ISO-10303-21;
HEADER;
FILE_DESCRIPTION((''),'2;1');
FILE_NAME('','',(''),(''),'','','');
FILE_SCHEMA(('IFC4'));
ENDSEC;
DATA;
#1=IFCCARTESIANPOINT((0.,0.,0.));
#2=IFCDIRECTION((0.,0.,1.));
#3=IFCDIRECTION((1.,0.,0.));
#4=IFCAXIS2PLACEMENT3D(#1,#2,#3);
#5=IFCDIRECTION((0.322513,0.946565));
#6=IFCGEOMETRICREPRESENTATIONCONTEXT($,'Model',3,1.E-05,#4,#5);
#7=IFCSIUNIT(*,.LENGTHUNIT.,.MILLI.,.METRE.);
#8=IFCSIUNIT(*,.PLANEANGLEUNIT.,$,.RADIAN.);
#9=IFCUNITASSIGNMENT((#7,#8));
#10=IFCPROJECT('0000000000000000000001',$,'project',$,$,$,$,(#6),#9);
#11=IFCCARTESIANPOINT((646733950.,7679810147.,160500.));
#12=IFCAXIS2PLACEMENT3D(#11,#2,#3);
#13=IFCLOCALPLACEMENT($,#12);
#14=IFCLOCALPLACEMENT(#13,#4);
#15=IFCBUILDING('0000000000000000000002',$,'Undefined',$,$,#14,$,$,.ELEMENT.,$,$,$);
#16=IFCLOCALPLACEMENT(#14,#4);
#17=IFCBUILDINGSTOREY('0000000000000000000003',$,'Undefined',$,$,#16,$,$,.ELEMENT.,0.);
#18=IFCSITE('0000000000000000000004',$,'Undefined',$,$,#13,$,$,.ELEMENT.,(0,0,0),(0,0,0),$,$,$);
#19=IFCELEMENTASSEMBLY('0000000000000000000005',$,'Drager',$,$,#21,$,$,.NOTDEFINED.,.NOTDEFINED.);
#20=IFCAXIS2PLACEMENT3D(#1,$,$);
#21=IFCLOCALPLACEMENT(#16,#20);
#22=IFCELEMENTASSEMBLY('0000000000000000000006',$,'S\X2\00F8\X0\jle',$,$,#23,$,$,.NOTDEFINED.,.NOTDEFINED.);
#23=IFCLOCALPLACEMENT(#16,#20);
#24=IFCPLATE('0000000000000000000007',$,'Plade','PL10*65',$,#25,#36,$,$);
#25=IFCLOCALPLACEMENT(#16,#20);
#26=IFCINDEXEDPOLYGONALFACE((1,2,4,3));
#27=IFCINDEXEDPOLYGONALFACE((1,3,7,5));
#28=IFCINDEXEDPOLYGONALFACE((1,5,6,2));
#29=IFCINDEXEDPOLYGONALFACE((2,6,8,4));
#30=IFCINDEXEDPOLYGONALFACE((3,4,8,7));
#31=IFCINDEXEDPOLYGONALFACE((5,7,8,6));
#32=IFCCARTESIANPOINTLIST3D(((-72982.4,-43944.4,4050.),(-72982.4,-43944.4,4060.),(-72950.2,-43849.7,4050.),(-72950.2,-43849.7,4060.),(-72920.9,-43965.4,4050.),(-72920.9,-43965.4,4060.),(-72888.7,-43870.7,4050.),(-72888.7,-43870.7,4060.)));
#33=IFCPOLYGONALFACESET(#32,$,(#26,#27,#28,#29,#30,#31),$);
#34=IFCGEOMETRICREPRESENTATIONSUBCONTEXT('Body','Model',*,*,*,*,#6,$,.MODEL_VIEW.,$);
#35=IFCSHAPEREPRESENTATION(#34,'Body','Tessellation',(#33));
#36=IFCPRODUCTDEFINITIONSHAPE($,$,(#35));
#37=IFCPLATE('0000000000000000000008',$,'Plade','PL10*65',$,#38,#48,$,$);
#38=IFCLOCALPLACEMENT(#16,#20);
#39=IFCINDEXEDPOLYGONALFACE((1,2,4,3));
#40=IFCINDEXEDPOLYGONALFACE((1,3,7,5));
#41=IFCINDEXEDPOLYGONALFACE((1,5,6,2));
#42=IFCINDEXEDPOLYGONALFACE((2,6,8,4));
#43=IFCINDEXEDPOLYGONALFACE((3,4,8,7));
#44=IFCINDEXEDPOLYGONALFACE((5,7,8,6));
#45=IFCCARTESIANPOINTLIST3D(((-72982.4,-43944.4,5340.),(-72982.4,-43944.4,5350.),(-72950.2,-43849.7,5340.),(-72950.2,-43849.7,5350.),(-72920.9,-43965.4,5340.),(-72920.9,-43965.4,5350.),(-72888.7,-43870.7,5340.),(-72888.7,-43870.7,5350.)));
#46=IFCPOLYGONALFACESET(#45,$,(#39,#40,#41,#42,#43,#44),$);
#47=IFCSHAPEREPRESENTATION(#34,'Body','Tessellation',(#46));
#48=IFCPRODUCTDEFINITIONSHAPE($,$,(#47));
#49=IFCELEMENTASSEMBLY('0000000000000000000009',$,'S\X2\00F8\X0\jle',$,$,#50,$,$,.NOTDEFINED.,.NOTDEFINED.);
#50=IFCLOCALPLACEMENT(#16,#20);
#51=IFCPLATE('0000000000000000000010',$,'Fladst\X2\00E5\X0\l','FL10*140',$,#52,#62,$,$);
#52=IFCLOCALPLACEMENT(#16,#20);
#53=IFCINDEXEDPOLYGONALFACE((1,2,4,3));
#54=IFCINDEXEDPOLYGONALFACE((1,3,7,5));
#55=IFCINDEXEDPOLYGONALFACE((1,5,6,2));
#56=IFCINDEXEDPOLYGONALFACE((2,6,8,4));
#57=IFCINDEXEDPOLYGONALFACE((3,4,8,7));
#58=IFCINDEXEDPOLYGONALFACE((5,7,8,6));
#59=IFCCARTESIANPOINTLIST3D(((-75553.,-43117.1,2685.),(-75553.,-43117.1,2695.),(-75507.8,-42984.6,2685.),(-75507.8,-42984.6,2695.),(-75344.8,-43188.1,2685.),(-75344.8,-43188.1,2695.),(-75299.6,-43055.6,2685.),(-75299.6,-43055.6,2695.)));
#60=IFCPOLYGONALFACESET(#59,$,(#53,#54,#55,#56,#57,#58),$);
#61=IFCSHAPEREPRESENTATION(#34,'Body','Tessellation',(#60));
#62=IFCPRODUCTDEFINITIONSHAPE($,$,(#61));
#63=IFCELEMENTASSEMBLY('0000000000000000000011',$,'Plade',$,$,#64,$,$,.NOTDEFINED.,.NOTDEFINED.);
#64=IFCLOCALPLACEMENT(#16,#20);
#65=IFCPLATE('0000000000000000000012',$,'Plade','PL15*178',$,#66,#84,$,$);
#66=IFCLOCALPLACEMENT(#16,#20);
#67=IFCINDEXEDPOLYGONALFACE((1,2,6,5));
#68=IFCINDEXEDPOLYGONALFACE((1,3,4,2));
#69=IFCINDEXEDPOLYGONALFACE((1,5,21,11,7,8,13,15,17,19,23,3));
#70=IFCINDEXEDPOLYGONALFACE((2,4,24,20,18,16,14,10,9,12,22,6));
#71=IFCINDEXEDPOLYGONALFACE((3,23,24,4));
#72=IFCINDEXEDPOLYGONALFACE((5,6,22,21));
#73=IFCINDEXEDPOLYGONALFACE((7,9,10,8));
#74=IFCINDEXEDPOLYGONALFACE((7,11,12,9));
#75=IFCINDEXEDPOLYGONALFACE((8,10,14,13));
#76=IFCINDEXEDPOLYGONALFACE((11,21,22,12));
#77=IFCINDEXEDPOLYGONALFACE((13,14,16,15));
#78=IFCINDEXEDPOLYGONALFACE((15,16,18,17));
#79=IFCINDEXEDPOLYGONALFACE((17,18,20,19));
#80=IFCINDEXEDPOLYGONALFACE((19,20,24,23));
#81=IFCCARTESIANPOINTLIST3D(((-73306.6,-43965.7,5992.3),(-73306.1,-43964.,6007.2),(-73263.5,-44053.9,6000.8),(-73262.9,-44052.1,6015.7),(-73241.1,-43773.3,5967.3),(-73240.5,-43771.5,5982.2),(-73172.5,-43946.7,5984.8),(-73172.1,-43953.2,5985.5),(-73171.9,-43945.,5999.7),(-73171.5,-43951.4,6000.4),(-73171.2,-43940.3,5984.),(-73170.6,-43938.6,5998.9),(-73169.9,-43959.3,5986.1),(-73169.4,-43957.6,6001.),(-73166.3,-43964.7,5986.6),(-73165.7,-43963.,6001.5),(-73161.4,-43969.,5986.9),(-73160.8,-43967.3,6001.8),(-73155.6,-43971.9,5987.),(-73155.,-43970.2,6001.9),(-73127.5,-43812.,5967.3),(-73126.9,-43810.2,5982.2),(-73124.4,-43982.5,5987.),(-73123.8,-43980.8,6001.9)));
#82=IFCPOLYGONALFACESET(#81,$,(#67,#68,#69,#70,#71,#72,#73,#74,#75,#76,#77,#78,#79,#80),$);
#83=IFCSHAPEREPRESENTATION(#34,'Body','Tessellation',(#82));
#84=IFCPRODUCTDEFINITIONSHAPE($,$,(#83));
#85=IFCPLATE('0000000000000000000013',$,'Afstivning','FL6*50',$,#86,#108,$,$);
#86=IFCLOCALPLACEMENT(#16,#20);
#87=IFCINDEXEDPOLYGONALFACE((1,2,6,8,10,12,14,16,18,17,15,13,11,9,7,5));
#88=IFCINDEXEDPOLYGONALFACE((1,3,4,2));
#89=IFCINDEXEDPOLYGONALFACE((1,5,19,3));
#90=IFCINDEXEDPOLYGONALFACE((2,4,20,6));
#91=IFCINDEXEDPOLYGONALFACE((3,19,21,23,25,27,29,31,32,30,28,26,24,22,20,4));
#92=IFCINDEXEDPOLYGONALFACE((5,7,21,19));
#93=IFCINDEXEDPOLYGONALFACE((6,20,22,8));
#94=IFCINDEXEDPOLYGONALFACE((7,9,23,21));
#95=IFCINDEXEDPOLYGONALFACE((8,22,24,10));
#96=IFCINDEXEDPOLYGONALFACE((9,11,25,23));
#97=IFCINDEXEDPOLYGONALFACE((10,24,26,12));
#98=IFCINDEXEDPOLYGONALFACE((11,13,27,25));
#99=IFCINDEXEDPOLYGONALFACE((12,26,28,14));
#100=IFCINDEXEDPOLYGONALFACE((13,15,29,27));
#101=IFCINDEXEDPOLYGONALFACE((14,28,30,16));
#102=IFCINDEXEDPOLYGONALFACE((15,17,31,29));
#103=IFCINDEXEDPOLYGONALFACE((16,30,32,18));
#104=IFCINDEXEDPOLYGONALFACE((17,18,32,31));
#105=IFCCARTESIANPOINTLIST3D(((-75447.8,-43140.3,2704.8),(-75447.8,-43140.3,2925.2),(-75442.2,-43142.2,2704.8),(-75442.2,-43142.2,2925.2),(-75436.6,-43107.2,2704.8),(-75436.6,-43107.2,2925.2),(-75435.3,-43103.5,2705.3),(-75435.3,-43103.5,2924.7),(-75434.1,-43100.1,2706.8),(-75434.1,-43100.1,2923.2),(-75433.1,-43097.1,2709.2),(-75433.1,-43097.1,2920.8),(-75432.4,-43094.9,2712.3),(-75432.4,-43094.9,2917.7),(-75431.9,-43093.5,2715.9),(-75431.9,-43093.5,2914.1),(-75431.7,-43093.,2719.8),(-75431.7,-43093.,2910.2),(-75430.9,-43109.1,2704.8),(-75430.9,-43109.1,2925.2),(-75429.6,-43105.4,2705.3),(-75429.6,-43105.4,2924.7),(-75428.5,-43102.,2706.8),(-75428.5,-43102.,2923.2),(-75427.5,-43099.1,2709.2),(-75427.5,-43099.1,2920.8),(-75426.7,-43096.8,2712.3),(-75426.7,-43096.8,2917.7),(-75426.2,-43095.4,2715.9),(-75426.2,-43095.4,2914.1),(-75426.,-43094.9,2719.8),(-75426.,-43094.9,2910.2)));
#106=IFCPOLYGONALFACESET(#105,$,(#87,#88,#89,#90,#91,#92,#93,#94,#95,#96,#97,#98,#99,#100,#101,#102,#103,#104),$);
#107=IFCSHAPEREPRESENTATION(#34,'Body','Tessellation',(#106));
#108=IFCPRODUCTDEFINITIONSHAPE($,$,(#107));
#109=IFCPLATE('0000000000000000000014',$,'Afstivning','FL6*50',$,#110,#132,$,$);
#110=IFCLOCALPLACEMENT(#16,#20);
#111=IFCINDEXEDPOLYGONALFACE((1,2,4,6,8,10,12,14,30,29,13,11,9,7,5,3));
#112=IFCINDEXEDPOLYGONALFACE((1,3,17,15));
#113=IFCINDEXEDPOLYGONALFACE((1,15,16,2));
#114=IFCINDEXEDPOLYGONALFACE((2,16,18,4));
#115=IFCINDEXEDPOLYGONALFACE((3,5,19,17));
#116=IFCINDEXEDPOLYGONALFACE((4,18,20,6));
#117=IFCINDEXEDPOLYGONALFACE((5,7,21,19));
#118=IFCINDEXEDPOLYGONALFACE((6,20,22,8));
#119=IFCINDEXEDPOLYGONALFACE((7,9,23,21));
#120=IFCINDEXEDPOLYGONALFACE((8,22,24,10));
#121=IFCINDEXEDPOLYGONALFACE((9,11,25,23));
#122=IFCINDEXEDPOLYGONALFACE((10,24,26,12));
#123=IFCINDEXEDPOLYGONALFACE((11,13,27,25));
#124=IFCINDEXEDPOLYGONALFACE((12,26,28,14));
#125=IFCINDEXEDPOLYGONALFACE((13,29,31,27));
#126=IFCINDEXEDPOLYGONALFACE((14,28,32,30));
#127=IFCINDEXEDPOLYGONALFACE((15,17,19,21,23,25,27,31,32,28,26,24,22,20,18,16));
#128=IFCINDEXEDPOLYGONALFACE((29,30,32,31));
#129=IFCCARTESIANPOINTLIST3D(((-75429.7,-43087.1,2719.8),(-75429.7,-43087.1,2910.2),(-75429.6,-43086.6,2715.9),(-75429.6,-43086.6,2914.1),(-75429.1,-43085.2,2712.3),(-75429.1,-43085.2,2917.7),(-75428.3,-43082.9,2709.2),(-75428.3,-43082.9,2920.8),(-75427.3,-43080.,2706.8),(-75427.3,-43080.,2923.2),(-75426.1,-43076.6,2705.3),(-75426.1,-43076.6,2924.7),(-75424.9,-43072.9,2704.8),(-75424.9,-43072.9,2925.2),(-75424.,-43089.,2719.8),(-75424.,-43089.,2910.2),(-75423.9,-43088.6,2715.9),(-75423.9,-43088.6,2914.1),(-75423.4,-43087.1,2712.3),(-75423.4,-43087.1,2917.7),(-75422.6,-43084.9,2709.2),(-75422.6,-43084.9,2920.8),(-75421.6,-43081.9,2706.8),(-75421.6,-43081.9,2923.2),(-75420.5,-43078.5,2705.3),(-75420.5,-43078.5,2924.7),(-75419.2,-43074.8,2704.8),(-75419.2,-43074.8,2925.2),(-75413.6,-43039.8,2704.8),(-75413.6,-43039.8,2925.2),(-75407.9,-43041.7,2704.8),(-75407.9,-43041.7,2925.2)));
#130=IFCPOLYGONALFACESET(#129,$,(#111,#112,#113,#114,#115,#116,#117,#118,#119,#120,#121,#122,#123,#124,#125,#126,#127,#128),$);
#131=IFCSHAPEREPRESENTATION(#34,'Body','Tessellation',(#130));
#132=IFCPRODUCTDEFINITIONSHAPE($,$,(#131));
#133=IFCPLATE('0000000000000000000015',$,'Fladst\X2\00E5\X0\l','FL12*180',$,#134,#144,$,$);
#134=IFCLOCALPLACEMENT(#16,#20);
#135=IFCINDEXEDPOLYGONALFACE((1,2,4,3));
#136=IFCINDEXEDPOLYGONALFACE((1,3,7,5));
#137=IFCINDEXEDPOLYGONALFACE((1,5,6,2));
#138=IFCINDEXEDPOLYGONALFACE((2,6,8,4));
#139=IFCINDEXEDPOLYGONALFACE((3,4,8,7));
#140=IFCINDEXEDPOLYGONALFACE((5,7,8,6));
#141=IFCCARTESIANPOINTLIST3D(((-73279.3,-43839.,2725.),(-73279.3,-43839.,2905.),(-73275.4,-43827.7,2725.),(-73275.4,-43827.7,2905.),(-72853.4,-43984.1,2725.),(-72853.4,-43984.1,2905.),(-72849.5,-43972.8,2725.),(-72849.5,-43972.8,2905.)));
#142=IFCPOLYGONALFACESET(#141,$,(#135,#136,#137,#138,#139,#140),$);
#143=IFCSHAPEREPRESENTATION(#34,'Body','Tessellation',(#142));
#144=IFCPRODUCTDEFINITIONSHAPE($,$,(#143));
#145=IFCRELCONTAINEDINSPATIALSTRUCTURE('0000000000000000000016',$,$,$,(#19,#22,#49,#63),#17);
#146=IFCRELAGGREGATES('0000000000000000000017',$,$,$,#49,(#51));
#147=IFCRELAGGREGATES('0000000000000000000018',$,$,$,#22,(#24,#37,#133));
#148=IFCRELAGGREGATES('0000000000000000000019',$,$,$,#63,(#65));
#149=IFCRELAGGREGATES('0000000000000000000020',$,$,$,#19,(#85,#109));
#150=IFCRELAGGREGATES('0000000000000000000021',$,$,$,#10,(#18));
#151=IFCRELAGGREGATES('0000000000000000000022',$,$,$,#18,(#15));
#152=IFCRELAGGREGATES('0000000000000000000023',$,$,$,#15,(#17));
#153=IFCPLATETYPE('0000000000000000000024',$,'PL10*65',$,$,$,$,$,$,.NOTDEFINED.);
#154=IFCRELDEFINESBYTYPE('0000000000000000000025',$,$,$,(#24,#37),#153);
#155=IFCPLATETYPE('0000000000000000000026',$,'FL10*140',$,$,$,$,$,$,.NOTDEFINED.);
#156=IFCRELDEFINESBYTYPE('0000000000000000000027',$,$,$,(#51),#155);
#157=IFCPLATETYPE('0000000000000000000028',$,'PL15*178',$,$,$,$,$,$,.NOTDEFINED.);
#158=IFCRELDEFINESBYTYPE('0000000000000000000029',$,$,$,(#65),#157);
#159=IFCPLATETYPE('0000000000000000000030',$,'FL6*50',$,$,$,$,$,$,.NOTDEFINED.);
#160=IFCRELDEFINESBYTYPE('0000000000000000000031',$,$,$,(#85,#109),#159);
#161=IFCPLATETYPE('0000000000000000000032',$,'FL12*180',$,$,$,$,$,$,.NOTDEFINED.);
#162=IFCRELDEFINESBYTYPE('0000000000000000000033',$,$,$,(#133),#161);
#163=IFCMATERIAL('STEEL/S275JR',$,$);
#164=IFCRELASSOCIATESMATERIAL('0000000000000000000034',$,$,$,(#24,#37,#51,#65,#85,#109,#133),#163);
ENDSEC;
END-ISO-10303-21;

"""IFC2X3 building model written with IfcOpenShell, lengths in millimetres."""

from ifc_helpers import new_model, si_unit, direction, frame, frame_2d, origin_with_axes, place, context, subcontext, project, spatial, polyline, circle_curve, parameter, trimmed, segment, composite_curve, outline, extrude, material, type_object, element, aggregate, save


model = new_model("IFC2X3")

# Units and contexts
model_context = context("Model", 3, precision=1e-05, world=origin_with_axes(), true_north=direction((0.322513, 0.946565)))
body_context = subcontext(model_context, "Body", "Model", "MODEL_VIEW")
ifc_project = project(units=[si_unit("LENGTHUNIT", "METRE", prefix="MILLI"), si_unit("PLANEANGLEUNIT", "RADIAN")], contexts=[model_context])

# Site, building, storey
site_placement = place(None, frame((646733950.0, 7679810147.0, 160500.0), z_axis=(0.0, 0.0, 1.0), x_axis=(1.0, 0.0, 0.0)))
site = spatial("IfcSite", under=ifc_project, at=site_placement, Name="Undefined", CompositionType="ELEMENT", RefLatitude=(0, 0, 0), RefLongitude=(0, 0, 0))
building_placement = place(site_placement, origin_with_axes())
building = spatial("IfcBuilding", under=site, at=building_placement, Name="Undefined", CompositionType="ELEMENT")
storey_placement = place(building_placement, origin_with_axes())
storey = spatial("IfcBuildingStorey", under=building, at=storey_placement, Name="Undefined", CompositionType="ELEMENT", Elevation=0.0)

# Element assembly
assembly_1_placement = place(storey_placement, origin_with_axes())
assembly_1 = element("IfcElementAssembly", 1, at=assembly_1_placement, inside=storey, Name="Drager", AssemblyPlace="NOTDEFINED", PredefinedType="NOTDEFINED")

# Shared definitions
ifc_material_1 = material(Name="STEEL/S275JR")

# Element assembly
assembly_2_placement = place(storey_placement, origin_with_axes())
assembly_2 = element("IfcElementAssembly", 2, at=assembly_2_placement, inside=storey, Name="Søjle", AssemblyPlace="NOTDEFINED", PredefinedType="NOTDEFINED")

# Plates
plate_type_1 = type_object("IfcPlateType", Name="PL10*65", PredefinedType="NOTDEFINED")
plate_1_placement = place(assembly_2_placement, frame((-72982.4, -43944.4, 4055.0), z_axis=(0.0, 0.0, 1.0), x_axis=(0.946565, -0.322513, 0.0)))
plate_1 = element("IfcPlate", 3, at=plate_1_placement, type_object=plate_type_1, material=ifc_material_1, Name="Plade", Description="PL10*65", context=body_context, shape_type="SweptSolid", body=[
    extrude(outline(polyline([(0.0, 0.0), (65.0, 0.0), (65.0, 100.0), (0.0, 100.0), (0.0, 0.0)])), frame((0.0, 0.0, -5.0), z_axis=(0.0, 0.0, 1.0), x_axis=(1.0, 0.0, 0.0)), (0.0, 0.0, 1.0), 10.0),
])
plate_2_placement = place(assembly_2_placement, frame((-72982.4, -43944.4, 5345.0), z_axis=(0.0, 0.0, 1.0), x_axis=(0.946565, -0.322513, 0.0)))
plate_2 = element("IfcPlate", 4, at=plate_2_placement, type_object=plate_type_1, material=ifc_material_1, Name="Plade", Description="PL10*65", context=body_context, shape_type="SweptSolid", body=[
    extrude(outline(polyline([(0.0, 0.0), (65.0, 0.0), (65.0, 100.0), (0.0, 100.0), (0.0, 0.0)])), frame((0.0, 0.0, -5.0), z_axis=(0.0, 0.0, 1.0), x_axis=(1.0, 0.0, 0.0)), (0.0, 0.0, 1.0), 10.0),
])

# Element assemblies, plates
assembly_3_placement = place(storey_placement, origin_with_axes())
assembly_3 = element("IfcElementAssembly", 5, at=assembly_3_placement, inside=storey, Name="Søjle", AssemblyPlace="NOTDEFINED", PredefinedType="NOTDEFINED")
plate_type_2 = type_object("IfcPlateType", Name="FL10*140", PredefinedType="NOTDEFINED")
plate_3_placement = place(assembly_3_placement, frame((-75403.7, -43020.1, 2690.0), z_axis=(0.0, 0.0, -1.0), x_axis=(-0.322513, -0.946565, 0.0)))
plate_3 = element("IfcPlate", 6, at=plate_3_placement, type_object=plate_type_2, material=ifc_material_1, Name="Fladstål", Description="FL10*140", context=body_context, shape_type="SweptSolid", body=[
    extrude(outline(polyline([(0.0, -110.0), (0.0, 110.0), (140.0, 110.0), (140.0, -110.0), (0.0, -110.0)])), frame((0.0, 0.0, -5.0), z_axis=(0.0, 0.0, 1.0), x_axis=(1.0, 0.0, 0.0)), (0.0, 0.0, 1.0), 10.0),
])
aggregate(assembly_3, [plate_3])
assembly_4_placement = place(storey_placement, origin_with_axes())
assembly_4 = element("IfcElementAssembly", 7, at=assembly_4_placement, inside=storey, Name="Plade", AssemblyPlace="NOTDEFINED", PredefinedType="NOTDEFINED")
plate_type_3 = type_object("IfcPlateType", Name="PL15*178", PredefinedType="NOTDEFINED")
plate_4_placement = place(assembly_4_placement, frame((-73127.2, -43811.1, 5974.8), z_axis=(-0.039304, -0.115357, -0.992546), x_axis=(-0.320109, -0.93951, 0.121869)))
plate_4 = element("IfcPlate", 8, at=plate_4_placement, type_object=plate_type_3, material=ifc_material_1, Name="Plade", Description="PL15*178", context=body_context, shape_type="SweptSolid", body=[
    extrude(outline(composite_curve([segment(polyline([(0.0, 0.0), (136.6, 0.0)]), True, "CONTINUOUS"), segment(trimmed(circle_curve(frame_2d((136.6, -25.0), x_axis=(0.0, 1.0)), 25.0), [parameter(0.0)], [parameter(4.712327)], False, "PARAMETER"), True, "CONTINUOUS"), segment(polyline([(161.6, -25.0), (161.6, -57.9), (274.9, 50.8), (204.9, 120.0), (0.0, 120.0), (0.0, 0.0)]), True, "CONTINUOUS")], self_intersect=True)), frame((0.0, 0.0, -7.5), z_axis=(0.0, 0.0, 1.0), x_axis=(1.0, 0.0, 0.0)), (0.0, 0.0, 1.0), 15.0),
])

# Plates
plate_type_4 = type_object("IfcPlateType", Name="FL6*50", PredefinedType="NOTDEFINED")
plate_5_placement = place(assembly_1_placement, frame((-75428.9, -43093.9, 2704.8), z_axis=(-0.946565, 0.322513, 0.0), x_axis=(-0.322513, -0.946565, 0.0)))
plate_5 = element("IfcPlate", 9, at=plate_5_placement, type_object=plate_type_4, material=ifc_material_1, Name="Afstivning", Description="FL6*50", context=body_context, shape_type="SweptSolid", body=[
    extrude(outline(composite_curve([segment(trimmed(circle_curve(frame_2d((15.0, 15.0), x_axis=(-1.0, 0.0)), 15.0), [parameter(0.0)], [parameter(1.570796)], True, "PARAMETER"), True, "CONTINUOUS"), segment(polyline([(15.0, 0.0), (50.0, 0.0), (50.0, 220.4), (15.0, 220.4)]), True, "CONTINUOUS"), segment(trimmed(circle_curve(frame_2d((15.0, 205.4), x_axis=(0.0, 1.0)), 15.0), [parameter(0.0)], [parameter(1.570796)], True, "PARAMETER"), True, "CONTINUOUS"), segment(polyline([(0.0, 205.4), (0.0, 15.0)]), True, "CONTINUOUS")], self_intersect=True)), frame((0.0, 0.0, -3.0), z_axis=(0.0, 0.0, 1.0), x_axis=(1.0, 0.0, 0.0)), (0.0, 0.0, 1.0), 6.0),
])
plate_6_placement = place(assembly_1_placement, frame((-75410.8, -43040.7, 2704.8), z_axis=(-0.946565, 0.322513, 0.0), x_axis=(-0.322513, -0.946565, 0.0)))
plate_6 = element("IfcPlate", 10, at=plate_6_placement, type_object=plate_type_4, material=ifc_material_1, Name="Afstivning", Description="FL6*50", context=body_context, shape_type="SweptSolid", body=[
    extrude(outline(composite_curve([segment(polyline([(0.0, 0.0), (35.0, 0.0)]), True, "CONTINUOUS"), segment(trimmed(circle_curve(frame_2d((35.0, 15.0), x_axis=(0.0, -1.0)), 15.0), [parameter(0.0)], [parameter(1.570796)], True, "PARAMETER"), True, "CONTINUOUS"), segment(polyline([(50.0, 15.0), (50.0, 205.4)]), True, "CONTINUOUS"), segment(trimmed(circle_curve(frame_2d((35.0, 205.4), x_axis=(1.0, 0.0)), 15.0), [parameter(0.0)], [parameter(1.570796)], True, "PARAMETER"), True, "CONTINUOUS"), segment(polyline([(35.0, 220.4), (0.0, 220.4), (0.0, 0.0)]), True, "CONTINUOUS")], self_intersect=True)), frame((0.0, 0.0, -3.0), z_axis=(0.0, 0.0, 1.0), x_axis=(1.0, 0.0, 0.0)), (0.0, 0.0, 1.0), 6.0),
])
plate_type_5 = type_object("IfcPlateType", Name="FL12*180", PredefinedType="NOTDEFINED")
plate_7_placement = place(assembly_2_placement, frame((-73277.4, -43833.3, 2905.0), z_axis=(-0.322513, -0.946565, 0.0), x_axis=(0.0, 0.0, -1.0)))
plate_7 = element("IfcPlate", 11, at=plate_7_placement, type_object=plate_type_5, material=ifc_material_1, Name="Fladstål", Description="FL12*180", context=body_context, shape_type="SweptSolid", body=[
    extrude(outline(polyline([(0.0, 0.0), (180.0, 0.0), (180.0, 450.0), (0.0, 450.0), (0.0, 0.0)])), frame((0.0, 0.0, -6.0), z_axis=(0.0, 0.0, 1.0), x_axis=(1.0, 0.0, 0.0)), (0.0, 0.0, 1.0), 12.0),
])
aggregate(assembly_2, [plate_1, plate_2, plate_7])

aggregate(assembly_4, [plate_4])
aggregate(assembly_1, [plate_5, plate_6])

save(model, "model.ifc")
